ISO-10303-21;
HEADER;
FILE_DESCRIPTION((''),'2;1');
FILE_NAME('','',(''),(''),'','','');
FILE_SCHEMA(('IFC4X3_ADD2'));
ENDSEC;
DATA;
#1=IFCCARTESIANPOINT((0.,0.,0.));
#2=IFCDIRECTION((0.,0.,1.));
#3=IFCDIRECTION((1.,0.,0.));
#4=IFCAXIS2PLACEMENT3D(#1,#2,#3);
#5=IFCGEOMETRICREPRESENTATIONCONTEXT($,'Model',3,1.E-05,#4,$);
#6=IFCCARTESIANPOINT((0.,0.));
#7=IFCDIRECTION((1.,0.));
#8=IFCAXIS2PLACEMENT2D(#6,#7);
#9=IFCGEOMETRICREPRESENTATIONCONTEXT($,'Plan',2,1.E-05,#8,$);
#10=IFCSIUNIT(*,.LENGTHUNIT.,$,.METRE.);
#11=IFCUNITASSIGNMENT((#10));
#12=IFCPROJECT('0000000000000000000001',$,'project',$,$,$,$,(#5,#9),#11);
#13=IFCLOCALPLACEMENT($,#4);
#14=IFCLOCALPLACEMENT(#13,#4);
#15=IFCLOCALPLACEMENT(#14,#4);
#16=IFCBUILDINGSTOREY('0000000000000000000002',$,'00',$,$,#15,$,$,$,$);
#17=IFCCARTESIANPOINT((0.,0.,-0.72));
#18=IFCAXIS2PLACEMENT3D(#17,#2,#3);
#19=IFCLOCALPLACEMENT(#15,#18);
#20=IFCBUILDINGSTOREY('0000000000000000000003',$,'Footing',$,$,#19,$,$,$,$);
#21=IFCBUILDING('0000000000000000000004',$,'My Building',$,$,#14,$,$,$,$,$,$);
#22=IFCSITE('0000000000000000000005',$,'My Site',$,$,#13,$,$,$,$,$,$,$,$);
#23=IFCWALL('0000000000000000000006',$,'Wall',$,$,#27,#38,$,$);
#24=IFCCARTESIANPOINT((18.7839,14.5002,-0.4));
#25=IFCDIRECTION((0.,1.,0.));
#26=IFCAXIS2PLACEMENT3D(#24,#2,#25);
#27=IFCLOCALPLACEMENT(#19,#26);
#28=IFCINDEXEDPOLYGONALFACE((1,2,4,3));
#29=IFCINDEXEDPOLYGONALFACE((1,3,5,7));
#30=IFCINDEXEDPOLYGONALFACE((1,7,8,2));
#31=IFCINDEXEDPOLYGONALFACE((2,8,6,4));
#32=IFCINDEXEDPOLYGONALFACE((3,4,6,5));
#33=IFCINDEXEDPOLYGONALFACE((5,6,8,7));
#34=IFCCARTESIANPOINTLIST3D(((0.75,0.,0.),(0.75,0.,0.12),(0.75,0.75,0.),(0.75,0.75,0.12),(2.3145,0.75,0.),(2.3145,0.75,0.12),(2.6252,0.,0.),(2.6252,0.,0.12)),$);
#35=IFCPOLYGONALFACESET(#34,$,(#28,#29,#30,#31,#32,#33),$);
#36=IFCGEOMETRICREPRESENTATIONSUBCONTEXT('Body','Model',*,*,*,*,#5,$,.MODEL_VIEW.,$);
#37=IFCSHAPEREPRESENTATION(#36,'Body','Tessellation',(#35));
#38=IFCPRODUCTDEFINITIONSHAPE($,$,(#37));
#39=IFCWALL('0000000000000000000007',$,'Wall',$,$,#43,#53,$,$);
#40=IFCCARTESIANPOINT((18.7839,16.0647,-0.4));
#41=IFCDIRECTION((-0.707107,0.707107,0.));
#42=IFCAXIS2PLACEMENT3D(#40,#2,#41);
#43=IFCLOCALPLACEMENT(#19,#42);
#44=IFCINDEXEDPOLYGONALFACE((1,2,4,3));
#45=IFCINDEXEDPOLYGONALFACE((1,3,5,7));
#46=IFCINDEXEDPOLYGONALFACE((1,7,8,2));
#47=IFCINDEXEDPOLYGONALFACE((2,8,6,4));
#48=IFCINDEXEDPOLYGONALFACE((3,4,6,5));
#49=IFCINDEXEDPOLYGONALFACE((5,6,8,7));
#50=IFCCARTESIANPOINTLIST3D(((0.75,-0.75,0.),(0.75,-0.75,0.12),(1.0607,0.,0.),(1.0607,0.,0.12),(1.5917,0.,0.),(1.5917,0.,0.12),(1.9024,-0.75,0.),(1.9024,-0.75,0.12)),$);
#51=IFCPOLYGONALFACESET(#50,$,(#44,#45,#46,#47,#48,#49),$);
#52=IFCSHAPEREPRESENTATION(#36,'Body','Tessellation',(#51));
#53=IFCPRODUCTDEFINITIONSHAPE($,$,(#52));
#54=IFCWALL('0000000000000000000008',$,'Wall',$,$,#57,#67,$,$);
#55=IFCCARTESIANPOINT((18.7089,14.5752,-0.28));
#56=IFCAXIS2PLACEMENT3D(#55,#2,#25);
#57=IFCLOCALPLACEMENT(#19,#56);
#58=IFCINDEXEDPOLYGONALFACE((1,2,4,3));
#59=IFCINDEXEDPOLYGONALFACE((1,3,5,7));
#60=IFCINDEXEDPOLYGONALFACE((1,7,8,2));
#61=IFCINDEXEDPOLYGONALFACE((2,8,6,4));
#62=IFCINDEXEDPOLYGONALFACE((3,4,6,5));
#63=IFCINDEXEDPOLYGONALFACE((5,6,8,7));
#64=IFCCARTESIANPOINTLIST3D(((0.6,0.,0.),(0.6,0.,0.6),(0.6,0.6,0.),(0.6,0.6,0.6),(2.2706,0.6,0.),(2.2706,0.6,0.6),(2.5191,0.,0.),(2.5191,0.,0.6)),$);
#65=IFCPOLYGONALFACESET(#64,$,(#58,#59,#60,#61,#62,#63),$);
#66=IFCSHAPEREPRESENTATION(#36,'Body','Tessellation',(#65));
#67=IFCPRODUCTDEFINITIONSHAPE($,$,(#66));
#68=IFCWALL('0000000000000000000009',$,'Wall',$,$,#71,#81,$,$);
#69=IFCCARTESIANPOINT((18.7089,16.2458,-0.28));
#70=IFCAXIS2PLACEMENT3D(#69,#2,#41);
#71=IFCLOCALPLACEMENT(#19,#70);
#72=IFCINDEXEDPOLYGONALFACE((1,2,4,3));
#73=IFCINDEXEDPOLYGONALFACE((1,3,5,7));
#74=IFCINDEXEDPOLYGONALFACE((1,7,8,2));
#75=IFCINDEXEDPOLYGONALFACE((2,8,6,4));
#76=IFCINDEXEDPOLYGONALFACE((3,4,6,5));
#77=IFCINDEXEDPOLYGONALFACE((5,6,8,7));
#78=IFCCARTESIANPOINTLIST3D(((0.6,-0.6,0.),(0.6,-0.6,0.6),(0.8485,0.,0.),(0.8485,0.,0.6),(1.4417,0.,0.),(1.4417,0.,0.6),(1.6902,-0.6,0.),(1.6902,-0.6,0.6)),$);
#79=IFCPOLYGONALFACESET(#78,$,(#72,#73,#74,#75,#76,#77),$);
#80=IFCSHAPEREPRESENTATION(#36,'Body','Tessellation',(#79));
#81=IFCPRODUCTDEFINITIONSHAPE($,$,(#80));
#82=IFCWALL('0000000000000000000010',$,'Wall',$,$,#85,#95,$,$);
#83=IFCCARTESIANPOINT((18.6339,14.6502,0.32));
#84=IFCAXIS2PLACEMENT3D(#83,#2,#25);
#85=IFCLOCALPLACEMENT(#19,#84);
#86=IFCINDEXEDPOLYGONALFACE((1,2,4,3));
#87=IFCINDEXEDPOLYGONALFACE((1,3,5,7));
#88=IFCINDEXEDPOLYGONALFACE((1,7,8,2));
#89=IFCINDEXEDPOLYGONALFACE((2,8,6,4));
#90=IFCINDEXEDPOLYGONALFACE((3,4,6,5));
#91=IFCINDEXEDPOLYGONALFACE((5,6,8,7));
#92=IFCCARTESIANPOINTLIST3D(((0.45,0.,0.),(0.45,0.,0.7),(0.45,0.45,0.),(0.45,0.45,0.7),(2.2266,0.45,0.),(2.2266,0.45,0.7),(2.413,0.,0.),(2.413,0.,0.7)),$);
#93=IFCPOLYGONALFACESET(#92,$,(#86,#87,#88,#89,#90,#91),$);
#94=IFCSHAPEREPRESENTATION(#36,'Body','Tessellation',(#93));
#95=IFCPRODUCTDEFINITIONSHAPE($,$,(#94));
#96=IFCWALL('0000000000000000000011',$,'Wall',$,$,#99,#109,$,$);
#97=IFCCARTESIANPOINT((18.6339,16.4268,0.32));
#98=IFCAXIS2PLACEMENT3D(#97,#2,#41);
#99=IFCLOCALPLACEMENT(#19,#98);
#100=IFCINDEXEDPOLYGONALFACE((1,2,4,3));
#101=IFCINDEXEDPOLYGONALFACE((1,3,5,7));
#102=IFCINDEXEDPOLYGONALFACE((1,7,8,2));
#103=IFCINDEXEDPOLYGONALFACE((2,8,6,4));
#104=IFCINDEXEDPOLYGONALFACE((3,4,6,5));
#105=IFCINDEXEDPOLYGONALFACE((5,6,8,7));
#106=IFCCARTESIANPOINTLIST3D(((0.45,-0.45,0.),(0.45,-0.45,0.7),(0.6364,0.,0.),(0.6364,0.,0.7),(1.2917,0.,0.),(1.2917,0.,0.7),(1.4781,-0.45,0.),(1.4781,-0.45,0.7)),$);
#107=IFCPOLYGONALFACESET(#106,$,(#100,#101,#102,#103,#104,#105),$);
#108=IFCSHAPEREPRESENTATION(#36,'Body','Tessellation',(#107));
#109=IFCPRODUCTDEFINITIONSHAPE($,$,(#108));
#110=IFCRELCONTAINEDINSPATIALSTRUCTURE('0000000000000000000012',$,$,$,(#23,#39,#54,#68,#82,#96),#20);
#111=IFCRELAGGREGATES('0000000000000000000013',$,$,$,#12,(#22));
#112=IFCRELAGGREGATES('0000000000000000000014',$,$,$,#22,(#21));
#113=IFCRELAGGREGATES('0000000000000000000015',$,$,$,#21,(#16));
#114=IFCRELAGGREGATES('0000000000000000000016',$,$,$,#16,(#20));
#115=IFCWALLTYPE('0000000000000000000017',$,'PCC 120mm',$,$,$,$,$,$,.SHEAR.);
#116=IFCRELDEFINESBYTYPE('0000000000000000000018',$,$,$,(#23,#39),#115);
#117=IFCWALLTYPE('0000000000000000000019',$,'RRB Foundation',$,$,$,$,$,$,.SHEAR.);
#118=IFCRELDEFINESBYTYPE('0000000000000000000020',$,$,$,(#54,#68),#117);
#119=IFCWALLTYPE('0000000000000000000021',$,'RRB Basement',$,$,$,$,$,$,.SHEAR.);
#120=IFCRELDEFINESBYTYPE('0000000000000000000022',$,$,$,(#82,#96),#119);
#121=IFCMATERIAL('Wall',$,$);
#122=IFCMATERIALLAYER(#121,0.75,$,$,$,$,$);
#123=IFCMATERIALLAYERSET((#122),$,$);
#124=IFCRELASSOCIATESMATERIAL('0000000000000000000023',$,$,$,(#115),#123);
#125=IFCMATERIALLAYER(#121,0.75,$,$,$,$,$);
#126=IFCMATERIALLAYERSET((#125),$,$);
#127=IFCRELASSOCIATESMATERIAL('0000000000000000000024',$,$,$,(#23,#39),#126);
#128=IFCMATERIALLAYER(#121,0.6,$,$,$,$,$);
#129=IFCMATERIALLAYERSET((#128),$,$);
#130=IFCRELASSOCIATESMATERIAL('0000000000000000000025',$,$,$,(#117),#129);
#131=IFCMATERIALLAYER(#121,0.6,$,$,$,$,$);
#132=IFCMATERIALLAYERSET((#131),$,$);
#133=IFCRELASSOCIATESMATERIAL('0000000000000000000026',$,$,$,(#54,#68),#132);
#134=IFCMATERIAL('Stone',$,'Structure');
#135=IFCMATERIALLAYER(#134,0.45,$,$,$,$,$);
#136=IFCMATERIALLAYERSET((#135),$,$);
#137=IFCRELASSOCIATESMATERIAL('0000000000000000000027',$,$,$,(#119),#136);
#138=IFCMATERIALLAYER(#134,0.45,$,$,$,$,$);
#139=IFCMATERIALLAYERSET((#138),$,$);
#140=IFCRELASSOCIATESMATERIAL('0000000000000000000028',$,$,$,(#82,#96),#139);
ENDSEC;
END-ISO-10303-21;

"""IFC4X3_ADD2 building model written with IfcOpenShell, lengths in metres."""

from ifc_helpers import new_model, si_unit, frame, origin_with_axes, origin_2d_with_axis, place, context, subcontext, project, spatial, line, indexed_curve, outline, extrude, material, layer, layer_set, layer_usage, type_object, element, save


model = new_model("IFC4X3_ADD2")

# Units and contexts
model_context = context("Model", 3, precision=1e-05, world=origin_with_axes())
plan_context = context("Plan", 2, precision=1e-05, world=origin_2d_with_axis())
body_context = subcontext(model_context, "Body", "Model", "MODEL_VIEW")
ifc_project = project(units=[si_unit("LENGTHUNIT", "METRE")], contexts=[model_context, plan_context])

# Site, building, storeys
site_placement = place(None, origin_with_axes())
site = spatial("IfcSite", under=ifc_project, at=site_placement, Name="My Site")
building_placement = place(site_placement, origin_with_axes())
building = spatial("IfcBuilding", under=site, at=building_placement, Name="My Building")
storey_1_placement = place(building_placement, origin_with_axes())
storey_1 = spatial("IfcBuildingStorey", under=building, at=storey_1_placement, Name="00")
storey_2_placement = place(storey_1_placement, frame((0.0, 0.0, -0.72), z_axis=(0.0, 0.0, 1.0), x_axis=(1.0, 0.0, 0.0)))
storey_2 = spatial("IfcBuildingStorey", under=storey_1, at=storey_2_placement, Name="Footing")

# Shared definitions
ifc_material_1 = material(Name="Wall")

# Walls
ifc_layer_1 = layer(ifc_material_1, 0.75)
ifc_layer_set_1 = layer_set([ifc_layer_1])
wall_type_1 = type_object("IfcWallType", Name="PCC 120mm", PredefinedType="SHEAR", material=ifc_layer_set_1)
ifc_layer_2 = layer(ifc_material_1, 0.75)
ifc_layer_set_2 = layer_set([ifc_layer_2])
ifc_layer_usage_1 = layer_usage(ifc_layer_set_2, "AXIS2", "POSITIVE", 0.0)
wall_1_placement = place(storey_2_placement, frame((18.7839, 14.5002, -0.4), z_axis=(0.0, 0.0, 1.0), x_axis=(0.0, 1.0, 0.0)))
element("IfcWall", 1, at=wall_1_placement, inside=storey_2, type_object=wall_type_1, material=ifc_layer_usage_1, Name="Wall", context=body_context, shape_type="SweptSolid", body=[
    extrude(outline(indexed_curve([(0.75, 0.0), (0.75, 0.75), (2.3145, 0.75), (2.6252, 0.0)], segments=[line(1, 2, 3, 4, 1)])), origin_with_axes(), (0.0, 0.0, 1.0), 0.12),
])
ifc_layer_usage_2 = layer_usage(ifc_layer_set_2, "AXIS2", "NEGATIVE", 0.0)
wall_2_placement = place(storey_2_placement, frame((18.7839, 16.0647, -0.4), z_axis=(0.0, 0.0, 1.0), x_axis=(-0.707107, 0.707107, 0.0)))
element("IfcWall", 2, at=wall_2_placement, inside=storey_2, type_object=wall_type_1, material=ifc_layer_usage_2, Name="Wall", context=body_context, shape_type="SweptSolid", body=[
    extrude(outline(indexed_curve([(0.75, -0.75), (1.0607, 0.0), (1.5917, 0.0), (1.9024, -0.75)], segments=[line(1, 2, 3, 4, 1)])), origin_with_axes(), (0.0, 0.0, 1.0), 0.12),
])
ifc_layer_3 = layer(ifc_material_1, 0.6)
ifc_layer_set_3 = layer_set([ifc_layer_3])
wall_type_2 = type_object("IfcWallType", Name="RRB Foundation", PredefinedType="SHEAR", material=ifc_layer_set_3)
ifc_layer_4 = layer(ifc_material_1, 0.6)
ifc_layer_set_4 = layer_set([ifc_layer_4])
ifc_layer_usage_3 = layer_usage(ifc_layer_set_4, "AXIS2", "POSITIVE", 0.0)
wall_3_placement = place(storey_2_placement, frame((18.7089, 14.5752, -0.28), z_axis=(0.0, 0.0, 1.0), x_axis=(0.0, 1.0, 0.0)))
element("IfcWall", 3, at=wall_3_placement, inside=storey_2, type_object=wall_type_2, material=ifc_layer_usage_3, Name="Wall", context=body_context, shape_type="SweptSolid", body=[
    extrude(outline(indexed_curve([(0.6, 0.0), (0.6, 0.6), (2.2706, 0.6), (2.5191, 0.0)], segments=[line(1, 2, 3, 4, 1)])), origin_with_axes(), (0.0, 0.0, 1.0), 0.6),
])
ifc_layer_usage_4 = layer_usage(ifc_layer_set_4, "AXIS2", "NEGATIVE", 0.0)
wall_4_placement = place(storey_2_placement, frame((18.7089, 16.2458, -0.28), z_axis=(0.0, 0.0, 1.0), x_axis=(-0.707107, 0.707107, 0.0)))
element("IfcWall", 4, at=wall_4_placement, inside=storey_2, type_object=wall_type_2, material=ifc_layer_usage_4, Name="Wall", context=body_context, shape_type="SweptSolid", body=[
    extrude(outline(indexed_curve([(0.6, -0.6), (0.8485, 0.0), (1.4417, 0.0), (1.6902, -0.6)], segments=[line(1, 2, 3, 4, 1)])), origin_with_axes(), (0.0, 0.0, 1.0), 0.6),
])
ifc_material_2 = material(Name="Stone", Category="Structure")
ifc_layer_5 = layer(ifc_material_2, 0.45)
ifc_layer_set_5 = layer_set([ifc_layer_5])
wall_type_3 = type_object("IfcWallType", Name="RRB Basement", PredefinedType="SHEAR", material=ifc_layer_set_5)
ifc_layer_6 = layer(ifc_material_2, 0.45)
ifc_layer_set_6 = layer_set([ifc_layer_6])
ifc_layer_usage_5 = layer_usage(ifc_layer_set_6, "AXIS2", "POSITIVE", 0.0)
wall_5_placement = place(storey_2_placement, frame((18.6339, 14.6502, 0.32), z_axis=(0.0, 0.0, 1.0), x_axis=(0.0, 1.0, 0.0)))
element("IfcWall", 5, at=wall_5_placement, inside=storey_2, type_object=wall_type_3, material=ifc_layer_usage_5, Name="Wall", context=body_context, shape_type="SweptSolid", body=[
    extrude(outline(indexed_curve([(0.45, 0.0), (0.45, 0.45), (2.2266, 0.45), (2.413, 0.0)], segments=[line(1, 2, 3, 4, 1)])), origin_with_axes(), (0.0, 0.0, 1.0), 0.7),
])
ifc_layer_usage_6 = layer_usage(ifc_layer_set_6, "AXIS2", "NEGATIVE", 0.0)
wall_6_placement = place(storey_2_placement, frame((18.6339, 16.4268, 0.32), z_axis=(0.0, 0.0, 1.0), x_axis=(-0.707107, 0.707107, 0.0)))
element("IfcWall", 6, at=wall_6_placement, inside=storey_2, type_object=wall_type_3, material=ifc_layer_usage_6, Name="Wall", context=body_context, shape_type="SweptSolid", body=[
    extrude(outline(indexed_curve([(0.45, -0.45), (0.6364, 0.0), (1.2917, 0.0), (1.4781, -0.45)], segments=[line(1, 2, 3, 4, 1)])), origin_with_axes(), (0.0, 0.0, 1.0), 0.7),
])

save(model, "model.ifc")
